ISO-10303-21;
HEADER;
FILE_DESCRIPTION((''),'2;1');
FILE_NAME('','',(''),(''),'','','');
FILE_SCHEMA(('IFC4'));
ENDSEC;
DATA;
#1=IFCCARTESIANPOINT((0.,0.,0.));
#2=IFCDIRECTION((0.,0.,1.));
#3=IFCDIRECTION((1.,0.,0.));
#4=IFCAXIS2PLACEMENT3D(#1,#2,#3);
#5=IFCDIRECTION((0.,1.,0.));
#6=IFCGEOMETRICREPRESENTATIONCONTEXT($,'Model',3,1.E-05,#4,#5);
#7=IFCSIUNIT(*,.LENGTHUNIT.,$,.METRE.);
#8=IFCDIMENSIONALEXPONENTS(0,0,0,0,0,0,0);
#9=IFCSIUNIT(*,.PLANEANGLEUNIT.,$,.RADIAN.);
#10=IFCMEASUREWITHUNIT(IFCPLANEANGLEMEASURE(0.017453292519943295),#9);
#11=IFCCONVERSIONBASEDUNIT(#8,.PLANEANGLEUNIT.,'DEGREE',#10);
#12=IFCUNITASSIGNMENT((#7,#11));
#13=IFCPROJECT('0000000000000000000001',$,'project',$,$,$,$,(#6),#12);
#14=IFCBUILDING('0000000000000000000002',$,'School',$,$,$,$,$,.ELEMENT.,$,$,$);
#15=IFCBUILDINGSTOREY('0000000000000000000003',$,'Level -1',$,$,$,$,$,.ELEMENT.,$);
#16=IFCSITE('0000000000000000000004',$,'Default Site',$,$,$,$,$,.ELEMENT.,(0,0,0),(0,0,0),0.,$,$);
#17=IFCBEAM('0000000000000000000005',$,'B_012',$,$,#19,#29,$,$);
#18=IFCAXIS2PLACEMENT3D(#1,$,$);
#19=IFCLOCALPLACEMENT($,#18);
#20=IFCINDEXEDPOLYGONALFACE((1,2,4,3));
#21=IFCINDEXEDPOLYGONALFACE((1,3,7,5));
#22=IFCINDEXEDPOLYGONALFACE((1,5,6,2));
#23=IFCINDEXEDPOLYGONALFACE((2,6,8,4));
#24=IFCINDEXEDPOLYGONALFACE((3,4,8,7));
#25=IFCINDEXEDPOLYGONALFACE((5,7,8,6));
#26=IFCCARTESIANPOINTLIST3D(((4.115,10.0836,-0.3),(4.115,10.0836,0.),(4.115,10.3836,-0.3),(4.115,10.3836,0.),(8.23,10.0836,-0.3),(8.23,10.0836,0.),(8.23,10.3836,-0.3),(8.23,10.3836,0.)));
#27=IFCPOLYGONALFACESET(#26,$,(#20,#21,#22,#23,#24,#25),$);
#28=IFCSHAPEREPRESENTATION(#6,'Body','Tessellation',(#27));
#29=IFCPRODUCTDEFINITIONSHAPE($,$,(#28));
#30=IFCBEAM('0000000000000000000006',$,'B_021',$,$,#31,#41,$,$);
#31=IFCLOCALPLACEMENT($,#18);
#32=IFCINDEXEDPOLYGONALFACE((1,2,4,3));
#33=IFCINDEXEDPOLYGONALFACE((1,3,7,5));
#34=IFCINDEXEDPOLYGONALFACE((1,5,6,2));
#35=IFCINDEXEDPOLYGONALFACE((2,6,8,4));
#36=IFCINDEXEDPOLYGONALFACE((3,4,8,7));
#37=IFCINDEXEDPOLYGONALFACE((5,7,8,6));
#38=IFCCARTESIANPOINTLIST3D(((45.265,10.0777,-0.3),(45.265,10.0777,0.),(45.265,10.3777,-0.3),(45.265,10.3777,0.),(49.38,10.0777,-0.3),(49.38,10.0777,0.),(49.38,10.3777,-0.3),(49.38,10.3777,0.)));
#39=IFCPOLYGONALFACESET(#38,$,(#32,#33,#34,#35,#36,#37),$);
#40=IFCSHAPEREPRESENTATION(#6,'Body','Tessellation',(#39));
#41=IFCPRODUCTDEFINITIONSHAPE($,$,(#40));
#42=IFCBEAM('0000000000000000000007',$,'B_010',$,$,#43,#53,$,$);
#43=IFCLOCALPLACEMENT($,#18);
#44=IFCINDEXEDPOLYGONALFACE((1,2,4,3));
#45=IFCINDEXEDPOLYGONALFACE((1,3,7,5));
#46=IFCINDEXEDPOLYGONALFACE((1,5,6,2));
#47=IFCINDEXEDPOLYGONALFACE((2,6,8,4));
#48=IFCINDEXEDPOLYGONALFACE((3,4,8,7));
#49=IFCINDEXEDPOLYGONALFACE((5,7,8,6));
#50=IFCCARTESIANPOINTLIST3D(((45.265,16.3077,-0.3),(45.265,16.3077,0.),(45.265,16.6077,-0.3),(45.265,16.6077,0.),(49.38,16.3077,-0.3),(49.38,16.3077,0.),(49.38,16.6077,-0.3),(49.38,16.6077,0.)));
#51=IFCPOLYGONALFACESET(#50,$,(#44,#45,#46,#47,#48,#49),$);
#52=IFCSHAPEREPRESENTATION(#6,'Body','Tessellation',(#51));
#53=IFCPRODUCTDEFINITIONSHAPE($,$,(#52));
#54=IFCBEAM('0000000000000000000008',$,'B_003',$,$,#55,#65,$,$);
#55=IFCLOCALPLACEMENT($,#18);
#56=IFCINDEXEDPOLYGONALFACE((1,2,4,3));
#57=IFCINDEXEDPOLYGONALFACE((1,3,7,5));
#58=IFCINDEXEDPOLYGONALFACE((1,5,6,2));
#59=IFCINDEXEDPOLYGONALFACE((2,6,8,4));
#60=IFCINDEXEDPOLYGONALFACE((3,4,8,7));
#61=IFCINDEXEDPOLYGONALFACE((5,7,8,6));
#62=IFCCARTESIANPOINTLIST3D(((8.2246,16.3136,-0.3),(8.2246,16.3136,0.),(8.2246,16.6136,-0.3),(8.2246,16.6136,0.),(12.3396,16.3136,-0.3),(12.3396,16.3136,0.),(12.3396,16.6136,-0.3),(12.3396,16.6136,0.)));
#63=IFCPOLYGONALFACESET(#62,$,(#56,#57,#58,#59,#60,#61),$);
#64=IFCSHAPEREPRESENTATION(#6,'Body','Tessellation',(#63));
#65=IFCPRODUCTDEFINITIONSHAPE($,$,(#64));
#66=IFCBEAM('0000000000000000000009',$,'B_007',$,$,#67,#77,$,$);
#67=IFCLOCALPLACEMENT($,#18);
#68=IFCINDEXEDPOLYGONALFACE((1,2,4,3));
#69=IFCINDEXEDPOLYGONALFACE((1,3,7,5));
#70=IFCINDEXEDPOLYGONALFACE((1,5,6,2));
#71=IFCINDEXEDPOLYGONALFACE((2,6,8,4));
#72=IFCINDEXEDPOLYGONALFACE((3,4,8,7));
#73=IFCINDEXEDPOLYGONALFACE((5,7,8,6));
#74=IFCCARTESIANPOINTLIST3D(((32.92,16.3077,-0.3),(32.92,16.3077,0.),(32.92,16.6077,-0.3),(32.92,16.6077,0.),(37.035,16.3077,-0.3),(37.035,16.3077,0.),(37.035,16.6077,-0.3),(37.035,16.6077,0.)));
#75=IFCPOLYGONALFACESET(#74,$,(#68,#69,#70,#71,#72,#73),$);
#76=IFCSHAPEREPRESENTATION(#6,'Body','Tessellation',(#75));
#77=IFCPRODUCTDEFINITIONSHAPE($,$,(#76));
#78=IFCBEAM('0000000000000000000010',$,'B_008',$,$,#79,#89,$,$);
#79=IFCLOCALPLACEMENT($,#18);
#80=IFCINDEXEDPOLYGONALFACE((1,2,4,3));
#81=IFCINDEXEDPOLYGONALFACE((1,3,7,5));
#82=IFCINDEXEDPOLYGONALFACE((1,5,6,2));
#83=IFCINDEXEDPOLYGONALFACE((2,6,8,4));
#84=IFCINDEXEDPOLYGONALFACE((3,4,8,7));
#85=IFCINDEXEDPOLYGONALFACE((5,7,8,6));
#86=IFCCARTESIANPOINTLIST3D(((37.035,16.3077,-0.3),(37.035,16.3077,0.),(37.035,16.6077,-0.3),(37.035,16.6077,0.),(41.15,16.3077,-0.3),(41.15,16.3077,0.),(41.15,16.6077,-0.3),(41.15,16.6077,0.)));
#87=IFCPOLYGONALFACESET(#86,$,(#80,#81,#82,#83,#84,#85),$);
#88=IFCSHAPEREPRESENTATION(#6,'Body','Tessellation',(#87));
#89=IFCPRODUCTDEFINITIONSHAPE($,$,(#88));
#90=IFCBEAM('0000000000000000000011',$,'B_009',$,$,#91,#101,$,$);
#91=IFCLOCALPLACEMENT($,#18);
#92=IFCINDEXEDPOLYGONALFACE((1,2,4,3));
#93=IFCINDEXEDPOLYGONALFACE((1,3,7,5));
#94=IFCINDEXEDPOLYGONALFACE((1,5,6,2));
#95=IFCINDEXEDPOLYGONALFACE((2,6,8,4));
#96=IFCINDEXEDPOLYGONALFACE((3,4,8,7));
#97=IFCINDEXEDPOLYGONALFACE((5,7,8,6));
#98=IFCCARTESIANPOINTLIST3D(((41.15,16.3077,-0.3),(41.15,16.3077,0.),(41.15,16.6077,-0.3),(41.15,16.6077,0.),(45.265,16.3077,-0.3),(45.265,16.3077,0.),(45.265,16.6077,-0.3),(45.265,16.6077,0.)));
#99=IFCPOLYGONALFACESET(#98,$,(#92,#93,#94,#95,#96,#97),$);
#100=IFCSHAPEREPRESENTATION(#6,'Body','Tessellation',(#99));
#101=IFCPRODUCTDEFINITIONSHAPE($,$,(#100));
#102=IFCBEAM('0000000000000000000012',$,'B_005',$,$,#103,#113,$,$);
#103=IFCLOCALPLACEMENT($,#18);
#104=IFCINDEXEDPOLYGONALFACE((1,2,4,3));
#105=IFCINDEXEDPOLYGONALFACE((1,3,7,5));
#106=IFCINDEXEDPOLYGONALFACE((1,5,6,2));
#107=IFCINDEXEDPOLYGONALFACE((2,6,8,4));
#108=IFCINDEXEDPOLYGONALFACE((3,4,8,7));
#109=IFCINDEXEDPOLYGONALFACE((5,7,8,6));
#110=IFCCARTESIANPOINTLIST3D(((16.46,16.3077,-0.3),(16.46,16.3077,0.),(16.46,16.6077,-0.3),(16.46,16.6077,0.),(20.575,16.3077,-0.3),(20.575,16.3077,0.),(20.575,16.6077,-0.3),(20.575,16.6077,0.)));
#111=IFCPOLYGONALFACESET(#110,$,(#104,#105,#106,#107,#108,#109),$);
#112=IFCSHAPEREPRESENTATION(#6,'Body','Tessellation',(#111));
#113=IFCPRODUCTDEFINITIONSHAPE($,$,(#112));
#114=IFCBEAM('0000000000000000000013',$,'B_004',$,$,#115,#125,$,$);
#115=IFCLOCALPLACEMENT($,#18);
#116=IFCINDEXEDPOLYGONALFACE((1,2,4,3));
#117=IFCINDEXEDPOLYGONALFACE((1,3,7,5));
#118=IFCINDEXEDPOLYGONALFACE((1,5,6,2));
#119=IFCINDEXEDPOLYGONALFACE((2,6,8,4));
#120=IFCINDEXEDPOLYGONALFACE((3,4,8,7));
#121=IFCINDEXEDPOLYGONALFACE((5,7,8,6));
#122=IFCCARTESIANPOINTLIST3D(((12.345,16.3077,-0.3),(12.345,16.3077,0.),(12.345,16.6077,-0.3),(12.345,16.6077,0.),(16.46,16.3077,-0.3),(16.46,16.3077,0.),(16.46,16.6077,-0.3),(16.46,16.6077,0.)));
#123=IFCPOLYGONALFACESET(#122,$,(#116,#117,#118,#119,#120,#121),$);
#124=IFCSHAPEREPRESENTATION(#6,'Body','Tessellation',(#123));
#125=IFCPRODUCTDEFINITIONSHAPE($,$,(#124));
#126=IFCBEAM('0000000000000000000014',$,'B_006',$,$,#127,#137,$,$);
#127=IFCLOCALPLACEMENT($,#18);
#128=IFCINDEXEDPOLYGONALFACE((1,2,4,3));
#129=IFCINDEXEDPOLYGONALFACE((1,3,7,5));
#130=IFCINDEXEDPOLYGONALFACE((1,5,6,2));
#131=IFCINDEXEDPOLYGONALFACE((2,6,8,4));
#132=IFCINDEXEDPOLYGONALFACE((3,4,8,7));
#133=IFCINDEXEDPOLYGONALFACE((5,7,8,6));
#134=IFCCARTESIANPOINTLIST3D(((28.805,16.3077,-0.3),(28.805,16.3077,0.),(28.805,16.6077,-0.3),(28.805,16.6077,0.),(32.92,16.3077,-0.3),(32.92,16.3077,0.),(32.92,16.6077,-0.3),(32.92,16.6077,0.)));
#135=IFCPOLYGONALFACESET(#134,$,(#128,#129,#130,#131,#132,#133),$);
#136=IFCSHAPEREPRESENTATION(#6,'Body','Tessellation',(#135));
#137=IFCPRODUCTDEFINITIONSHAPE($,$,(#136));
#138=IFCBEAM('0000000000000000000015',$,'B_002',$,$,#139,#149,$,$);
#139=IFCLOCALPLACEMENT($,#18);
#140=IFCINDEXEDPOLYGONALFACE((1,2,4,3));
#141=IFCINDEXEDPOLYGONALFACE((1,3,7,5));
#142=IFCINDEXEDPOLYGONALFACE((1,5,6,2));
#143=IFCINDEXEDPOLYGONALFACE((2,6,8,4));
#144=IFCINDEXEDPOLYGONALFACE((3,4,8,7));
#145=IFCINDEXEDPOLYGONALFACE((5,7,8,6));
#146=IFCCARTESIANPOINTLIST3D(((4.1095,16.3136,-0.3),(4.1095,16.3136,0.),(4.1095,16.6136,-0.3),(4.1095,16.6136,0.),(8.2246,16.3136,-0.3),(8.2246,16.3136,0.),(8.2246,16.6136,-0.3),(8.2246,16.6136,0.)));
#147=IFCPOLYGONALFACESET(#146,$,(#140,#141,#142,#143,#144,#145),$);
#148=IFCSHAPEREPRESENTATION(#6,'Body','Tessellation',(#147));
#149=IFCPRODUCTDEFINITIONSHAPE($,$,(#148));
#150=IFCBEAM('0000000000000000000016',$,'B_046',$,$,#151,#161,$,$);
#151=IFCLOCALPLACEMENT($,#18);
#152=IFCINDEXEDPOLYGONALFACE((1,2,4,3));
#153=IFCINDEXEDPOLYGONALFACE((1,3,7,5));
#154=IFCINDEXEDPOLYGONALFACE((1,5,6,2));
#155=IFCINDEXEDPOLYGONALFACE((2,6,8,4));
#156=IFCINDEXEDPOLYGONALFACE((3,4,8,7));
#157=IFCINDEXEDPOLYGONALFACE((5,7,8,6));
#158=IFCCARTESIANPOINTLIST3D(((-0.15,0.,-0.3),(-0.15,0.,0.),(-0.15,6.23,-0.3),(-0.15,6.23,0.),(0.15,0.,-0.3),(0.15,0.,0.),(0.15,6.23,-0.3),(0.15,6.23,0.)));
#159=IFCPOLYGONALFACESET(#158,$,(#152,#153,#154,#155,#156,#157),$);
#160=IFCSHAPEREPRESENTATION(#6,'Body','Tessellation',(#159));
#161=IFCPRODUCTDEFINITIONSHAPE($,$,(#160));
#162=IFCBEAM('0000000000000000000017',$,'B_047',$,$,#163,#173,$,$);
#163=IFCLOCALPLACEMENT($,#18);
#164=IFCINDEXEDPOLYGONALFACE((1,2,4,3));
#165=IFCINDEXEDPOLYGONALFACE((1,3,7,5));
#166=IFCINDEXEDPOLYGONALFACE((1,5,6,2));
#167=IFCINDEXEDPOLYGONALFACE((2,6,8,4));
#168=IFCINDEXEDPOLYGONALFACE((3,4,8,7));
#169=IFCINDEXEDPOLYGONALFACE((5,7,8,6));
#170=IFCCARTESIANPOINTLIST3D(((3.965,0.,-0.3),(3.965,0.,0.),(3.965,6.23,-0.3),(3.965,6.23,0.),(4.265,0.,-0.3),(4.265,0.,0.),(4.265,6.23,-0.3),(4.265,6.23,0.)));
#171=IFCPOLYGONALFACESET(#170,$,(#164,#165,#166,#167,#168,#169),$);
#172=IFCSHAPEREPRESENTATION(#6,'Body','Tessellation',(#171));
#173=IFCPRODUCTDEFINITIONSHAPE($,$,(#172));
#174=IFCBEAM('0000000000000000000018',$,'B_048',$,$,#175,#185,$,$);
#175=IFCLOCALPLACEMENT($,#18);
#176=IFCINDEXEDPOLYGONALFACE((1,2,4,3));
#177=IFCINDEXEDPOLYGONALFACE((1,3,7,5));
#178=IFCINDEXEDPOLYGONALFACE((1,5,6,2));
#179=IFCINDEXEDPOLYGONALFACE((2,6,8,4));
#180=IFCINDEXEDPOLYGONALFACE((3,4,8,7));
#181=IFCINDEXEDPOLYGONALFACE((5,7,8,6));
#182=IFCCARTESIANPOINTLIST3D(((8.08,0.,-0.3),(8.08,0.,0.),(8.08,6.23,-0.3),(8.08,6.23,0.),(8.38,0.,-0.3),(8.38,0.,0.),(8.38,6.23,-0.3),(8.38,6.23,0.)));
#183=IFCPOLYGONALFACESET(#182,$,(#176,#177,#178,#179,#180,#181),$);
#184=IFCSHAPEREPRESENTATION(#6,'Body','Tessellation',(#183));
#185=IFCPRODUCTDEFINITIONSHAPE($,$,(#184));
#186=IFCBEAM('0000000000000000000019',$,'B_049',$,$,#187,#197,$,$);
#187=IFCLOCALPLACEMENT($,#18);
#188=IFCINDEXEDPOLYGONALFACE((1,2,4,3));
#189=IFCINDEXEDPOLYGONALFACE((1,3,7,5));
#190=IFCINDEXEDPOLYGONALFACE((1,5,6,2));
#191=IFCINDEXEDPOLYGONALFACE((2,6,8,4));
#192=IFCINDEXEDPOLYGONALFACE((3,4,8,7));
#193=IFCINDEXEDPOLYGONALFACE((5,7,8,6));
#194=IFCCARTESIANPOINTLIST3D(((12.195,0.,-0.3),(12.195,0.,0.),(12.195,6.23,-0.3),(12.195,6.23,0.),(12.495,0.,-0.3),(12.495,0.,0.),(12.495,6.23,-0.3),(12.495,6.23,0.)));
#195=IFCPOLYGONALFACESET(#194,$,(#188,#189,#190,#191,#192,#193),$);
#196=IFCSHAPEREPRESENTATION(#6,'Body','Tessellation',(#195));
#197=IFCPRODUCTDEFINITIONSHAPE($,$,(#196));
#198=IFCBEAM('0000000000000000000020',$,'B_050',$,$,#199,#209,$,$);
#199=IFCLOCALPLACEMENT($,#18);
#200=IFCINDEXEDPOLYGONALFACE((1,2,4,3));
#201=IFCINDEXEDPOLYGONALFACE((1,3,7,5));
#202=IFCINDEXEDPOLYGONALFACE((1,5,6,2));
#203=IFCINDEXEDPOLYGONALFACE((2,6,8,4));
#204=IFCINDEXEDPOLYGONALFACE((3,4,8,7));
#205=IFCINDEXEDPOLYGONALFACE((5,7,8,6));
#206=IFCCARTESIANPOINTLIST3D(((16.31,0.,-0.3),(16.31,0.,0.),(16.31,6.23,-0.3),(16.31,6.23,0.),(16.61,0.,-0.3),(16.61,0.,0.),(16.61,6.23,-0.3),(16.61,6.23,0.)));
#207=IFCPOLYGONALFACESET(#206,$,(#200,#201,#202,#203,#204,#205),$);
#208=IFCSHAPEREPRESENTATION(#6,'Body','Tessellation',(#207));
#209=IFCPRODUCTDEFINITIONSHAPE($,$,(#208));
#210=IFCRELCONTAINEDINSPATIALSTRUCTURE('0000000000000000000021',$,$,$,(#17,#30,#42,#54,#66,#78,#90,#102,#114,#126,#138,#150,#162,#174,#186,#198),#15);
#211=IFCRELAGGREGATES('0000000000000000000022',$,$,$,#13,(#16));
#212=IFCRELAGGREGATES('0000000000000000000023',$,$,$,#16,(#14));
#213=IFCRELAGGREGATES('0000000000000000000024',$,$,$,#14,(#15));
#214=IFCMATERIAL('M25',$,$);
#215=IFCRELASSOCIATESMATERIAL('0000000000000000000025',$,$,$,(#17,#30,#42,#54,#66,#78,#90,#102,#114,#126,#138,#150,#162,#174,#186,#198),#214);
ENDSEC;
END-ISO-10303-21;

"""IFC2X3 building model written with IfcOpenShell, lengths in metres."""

from ifc_helpers import new_model, entity, si_unit, converted_unit, direction, frame, frame_2d, origin_with_axes, place, context, project, spatial, rectangle, extrude, material, element, save


model = new_model("IFC2X3")

# Units and contexts
model_context = context("Model", 3, precision=1e-05, world=origin_with_axes(), true_north=direction((0.0, 1.0, 0.0)))
ifc_project = project(units=[si_unit("LENGTHUNIT", "METRE"), converted_unit("PLANEANGLEUNIT", "DEGREE", entity("IfcPlaneAngleMeasure", 0.017453292519943295), si_unit("PLANEANGLEUNIT", "RADIAN"), dimensions=[0, 0, 0, 0, 0, 0, 0])], contexts=[model_context])

# Site, building, storey
site = spatial("IfcSite", under=ifc_project, Name="Default Site", CompositionType="ELEMENT", RefLatitude=(0, 0, 0), RefLongitude=(0, 0, 0), RefElevation=0.0)
building = spatial("IfcBuilding", under=site, Name="School", CompositionType="ELEMENT")
storey = spatial("IfcBuildingStorey", under=building, Name="Level -1", CompositionType="ELEMENT")

# Beams
ifc_material = material(Name="M25")
placement = place(None, origin_with_axes())
element("IfcBeam", 1, at=placement, inside=storey, material=ifc_material, Name="B_012", context=model_context, shape_type="SweptSolid", body=[
    extrude(rectangle(XDim=0.3, YDim=0.3, at=frame_2d((0.0, 0.0), x_axis=(0.0, 1.0, 0.0))), frame((4.115, 10.2336, -0.15), z_axis=(1.0, 0.0, 0.0), x_axis=(0.0, 0.0, -1.0)), (0.0, 0.0, 1.0), 4.115),
])
element("IfcBeam", 2, at=placement, inside=storey, material=ifc_material, Name="B_021", context=model_context, shape_type="SweptSolid", body=[
    extrude(rectangle(XDim=0.3, YDim=0.3, at=frame_2d((0.0, 0.0), x_axis=(0.0, 1.0, 0.0))), frame((45.265, 10.2277, -0.15), z_axis=(1.0, 0.0, 0.0), x_axis=(0.0, 0.0, -1.0)), (0.0, 0.0, 1.0), 4.115),
])
element("IfcBeam", 3, at=placement, inside=storey, material=ifc_material, Name="B_010", context=model_context, shape_type="SweptSolid", body=[
    extrude(rectangle(XDim=0.3, YDim=0.3, at=frame_2d((0.0, 0.0), x_axis=(0.0, 1.0, 0.0))), frame((45.265, 16.4577, -0.15), z_axis=(1.0, 0.0, 0.0), x_axis=(0.0, 0.0, -1.0)), (0.0, 0.0, 1.0), 4.115),
])
element("IfcBeam", 4, at=placement, inside=storey, material=ifc_material, Name="B_003", context=model_context, shape_type="SweptSolid", body=[
    extrude(rectangle(XDim=0.3, YDim=0.3, at=frame_2d((0.0, 0.0), x_axis=(0.0, 1.0, 0.0))), frame((8.2246, 16.4636, -0.15), z_axis=(1.0, 0.0, 0.0), x_axis=(0.0, 0.0, -1.0)), (0.0, 0.0, 1.0), 4.115),
])
element("IfcBeam", 5, at=placement, inside=storey, material=ifc_material, Name="B_007", context=model_context, shape_type="SweptSolid", body=[
    extrude(rectangle(XDim=0.3, YDim=0.3, at=frame_2d((0.0, 0.0), x_axis=(0.0, 1.0, 0.0))), frame((32.92, 16.4577, -0.15), z_axis=(1.0, 0.0, 0.0), x_axis=(0.0, 0.0, -1.0)), (0.0, 0.0, 1.0), 4.115),
])
element("IfcBeam", 6, at=placement, inside=storey, material=ifc_material, Name="B_008", context=model_context, shape_type="SweptSolid", body=[
    extrude(rectangle(XDim=0.3, YDim=0.3, at=frame_2d((0.0, 0.0), x_axis=(0.0, 1.0, 0.0))), frame((37.035, 16.4577, -0.15), z_axis=(1.0, 0.0, 0.0), x_axis=(0.0, 0.0, -1.0)), (0.0, 0.0, 1.0), 4.115),
])
element("IfcBeam", 7, at=placement, inside=storey, material=ifc_material, Name="B_009", context=model_context, shape_type="SweptSolid", body=[
    extrude(rectangle(XDim=0.3, YDim=0.3, at=frame_2d((0.0, 0.0), x_axis=(0.0, 1.0, 0.0))), frame((41.15, 16.4577, -0.15), z_axis=(1.0, 0.0, 0.0), x_axis=(0.0, 0.0, -1.0)), (0.0, 0.0, 1.0), 4.115),
])
element("IfcBeam", 8, at=placement, inside=storey, material=ifc_material, Name="B_005", context=model_context, shape_type="SweptSolid", body=[
    extrude(rectangle(XDim=0.3, YDim=0.3, at=frame_2d((0.0, 0.0), x_axis=(0.0, 1.0, 0.0))), frame((16.46, 16.4577, -0.15), z_axis=(1.0, 0.0, 0.0), x_axis=(0.0, 0.0, -1.0)), (0.0, 0.0, 1.0), 4.115),
])
element("IfcBeam", 9, at=placement, inside=storey, material=ifc_material, Name="B_004", context=model_context, shape_type="SweptSolid", body=[
    extrude(rectangle(XDim=0.3, YDim=0.3, at=frame_2d((0.0, 0.0), x_axis=(0.0, 1.0, 0.0))), frame((12.345, 16.4577, -0.15), z_axis=(1.0, 0.0, 0.0), x_axis=(0.0, 0.0, -1.0)), (0.0, 0.0, 1.0), 4.115),
])
element("IfcBeam", 10, at=placement, inside=storey, material=ifc_material, Name="B_006", context=model_context, shape_type="SweptSolid", body=[
    extrude(rectangle(XDim=0.3, YDim=0.3, at=frame_2d((0.0, 0.0), x_axis=(0.0, 1.0, 0.0))), frame((28.805, 16.4577, -0.15), z_axis=(1.0, 0.0, 0.0), x_axis=(0.0, 0.0, -1.0)), (0.0, 0.0, 1.0), 4.115),
])
element("IfcBeam", 11, at=placement, inside=storey, material=ifc_material, Name="B_002", context=model_context, shape_type="SweptSolid", body=[
    extrude(rectangle(XDim=0.3, YDim=0.3, at=frame_2d((0.0, 0.0), x_axis=(0.0, 1.0, 0.0))), frame((4.1095, 16.4636, -0.15), z_axis=(1.0, 0.0, 0.0), x_axis=(0.0, 0.0, -1.0)), (0.0, 0.0, 1.0), 4.115),
])
element("IfcBeam", 12, at=placement, inside=storey, material=ifc_material, Name="B_046", context=model_context, shape_type="SweptSolid", body=[
    extrude(rectangle(XDim=0.3, YDim=0.3, at=frame_2d((0.0, 0.0), x_axis=(0.0, 1.0, 0.0))), frame((0.0, 0.0, -0.15), z_axis=(0.0, 1.0, 0.0), x_axis=(0.0, 0.0, -1.0)), (0.0, 0.0, 1.0), 6.23),
])
element("IfcBeam", 13, at=placement, inside=storey, material=ifc_material, Name="B_047", context=model_context, shape_type="SweptSolid", body=[
    extrude(rectangle(XDim=0.3, YDim=0.3, at=frame_2d((0.0, 0.0), x_axis=(0.0, 1.0, 0.0))), frame((4.115, 0.0, -0.15), z_axis=(0.0, 1.0, 0.0), x_axis=(0.0, 0.0, -1.0)), (0.0, 0.0, 1.0), 6.23),
])
element("IfcBeam", 14, at=placement, inside=storey, material=ifc_material, Name="B_048", context=model_context, shape_type="SweptSolid", body=[
    extrude(rectangle(XDim=0.3, YDim=0.3, at=frame_2d((0.0, 0.0), x_axis=(0.0, 1.0, 0.0))), frame((8.23, 0.0, -0.15), z_axis=(0.0, 1.0, 0.0), x_axis=(0.0, 0.0, -1.0)), (0.0, 0.0, 1.0), 6.23),
])
element("IfcBeam", 15, at=placement, inside=storey, material=ifc_material, Name="B_049", context=model_context, shape_type="SweptSolid", body=[
    extrude(rectangle(XDim=0.3, YDim=0.3, at=frame_2d((0.0, 0.0), x_axis=(0.0, 1.0, 0.0))), frame((12.345, 0.0, -0.15), z_axis=(0.0, 1.0, 0.0), x_axis=(0.0, 0.0, -1.0)), (0.0, 0.0, 1.0), 6.23),
])
element("IfcBeam", 16, at=placement, inside=storey, material=ifc_material, Name="B_050", context=model_context, shape_type="SweptSolid", body=[
    extrude(rectangle(XDim=0.3, YDim=0.3, at=frame_2d((0.0, 0.0), x_axis=(0.0, 1.0, 0.0))), frame((16.46, 0.0, -0.15), z_axis=(0.0, 1.0, 0.0), x_axis=(0.0, 0.0, -1.0)), (0.0, 0.0, 1.0), 6.23),
])

save(model, "model.ifc")
